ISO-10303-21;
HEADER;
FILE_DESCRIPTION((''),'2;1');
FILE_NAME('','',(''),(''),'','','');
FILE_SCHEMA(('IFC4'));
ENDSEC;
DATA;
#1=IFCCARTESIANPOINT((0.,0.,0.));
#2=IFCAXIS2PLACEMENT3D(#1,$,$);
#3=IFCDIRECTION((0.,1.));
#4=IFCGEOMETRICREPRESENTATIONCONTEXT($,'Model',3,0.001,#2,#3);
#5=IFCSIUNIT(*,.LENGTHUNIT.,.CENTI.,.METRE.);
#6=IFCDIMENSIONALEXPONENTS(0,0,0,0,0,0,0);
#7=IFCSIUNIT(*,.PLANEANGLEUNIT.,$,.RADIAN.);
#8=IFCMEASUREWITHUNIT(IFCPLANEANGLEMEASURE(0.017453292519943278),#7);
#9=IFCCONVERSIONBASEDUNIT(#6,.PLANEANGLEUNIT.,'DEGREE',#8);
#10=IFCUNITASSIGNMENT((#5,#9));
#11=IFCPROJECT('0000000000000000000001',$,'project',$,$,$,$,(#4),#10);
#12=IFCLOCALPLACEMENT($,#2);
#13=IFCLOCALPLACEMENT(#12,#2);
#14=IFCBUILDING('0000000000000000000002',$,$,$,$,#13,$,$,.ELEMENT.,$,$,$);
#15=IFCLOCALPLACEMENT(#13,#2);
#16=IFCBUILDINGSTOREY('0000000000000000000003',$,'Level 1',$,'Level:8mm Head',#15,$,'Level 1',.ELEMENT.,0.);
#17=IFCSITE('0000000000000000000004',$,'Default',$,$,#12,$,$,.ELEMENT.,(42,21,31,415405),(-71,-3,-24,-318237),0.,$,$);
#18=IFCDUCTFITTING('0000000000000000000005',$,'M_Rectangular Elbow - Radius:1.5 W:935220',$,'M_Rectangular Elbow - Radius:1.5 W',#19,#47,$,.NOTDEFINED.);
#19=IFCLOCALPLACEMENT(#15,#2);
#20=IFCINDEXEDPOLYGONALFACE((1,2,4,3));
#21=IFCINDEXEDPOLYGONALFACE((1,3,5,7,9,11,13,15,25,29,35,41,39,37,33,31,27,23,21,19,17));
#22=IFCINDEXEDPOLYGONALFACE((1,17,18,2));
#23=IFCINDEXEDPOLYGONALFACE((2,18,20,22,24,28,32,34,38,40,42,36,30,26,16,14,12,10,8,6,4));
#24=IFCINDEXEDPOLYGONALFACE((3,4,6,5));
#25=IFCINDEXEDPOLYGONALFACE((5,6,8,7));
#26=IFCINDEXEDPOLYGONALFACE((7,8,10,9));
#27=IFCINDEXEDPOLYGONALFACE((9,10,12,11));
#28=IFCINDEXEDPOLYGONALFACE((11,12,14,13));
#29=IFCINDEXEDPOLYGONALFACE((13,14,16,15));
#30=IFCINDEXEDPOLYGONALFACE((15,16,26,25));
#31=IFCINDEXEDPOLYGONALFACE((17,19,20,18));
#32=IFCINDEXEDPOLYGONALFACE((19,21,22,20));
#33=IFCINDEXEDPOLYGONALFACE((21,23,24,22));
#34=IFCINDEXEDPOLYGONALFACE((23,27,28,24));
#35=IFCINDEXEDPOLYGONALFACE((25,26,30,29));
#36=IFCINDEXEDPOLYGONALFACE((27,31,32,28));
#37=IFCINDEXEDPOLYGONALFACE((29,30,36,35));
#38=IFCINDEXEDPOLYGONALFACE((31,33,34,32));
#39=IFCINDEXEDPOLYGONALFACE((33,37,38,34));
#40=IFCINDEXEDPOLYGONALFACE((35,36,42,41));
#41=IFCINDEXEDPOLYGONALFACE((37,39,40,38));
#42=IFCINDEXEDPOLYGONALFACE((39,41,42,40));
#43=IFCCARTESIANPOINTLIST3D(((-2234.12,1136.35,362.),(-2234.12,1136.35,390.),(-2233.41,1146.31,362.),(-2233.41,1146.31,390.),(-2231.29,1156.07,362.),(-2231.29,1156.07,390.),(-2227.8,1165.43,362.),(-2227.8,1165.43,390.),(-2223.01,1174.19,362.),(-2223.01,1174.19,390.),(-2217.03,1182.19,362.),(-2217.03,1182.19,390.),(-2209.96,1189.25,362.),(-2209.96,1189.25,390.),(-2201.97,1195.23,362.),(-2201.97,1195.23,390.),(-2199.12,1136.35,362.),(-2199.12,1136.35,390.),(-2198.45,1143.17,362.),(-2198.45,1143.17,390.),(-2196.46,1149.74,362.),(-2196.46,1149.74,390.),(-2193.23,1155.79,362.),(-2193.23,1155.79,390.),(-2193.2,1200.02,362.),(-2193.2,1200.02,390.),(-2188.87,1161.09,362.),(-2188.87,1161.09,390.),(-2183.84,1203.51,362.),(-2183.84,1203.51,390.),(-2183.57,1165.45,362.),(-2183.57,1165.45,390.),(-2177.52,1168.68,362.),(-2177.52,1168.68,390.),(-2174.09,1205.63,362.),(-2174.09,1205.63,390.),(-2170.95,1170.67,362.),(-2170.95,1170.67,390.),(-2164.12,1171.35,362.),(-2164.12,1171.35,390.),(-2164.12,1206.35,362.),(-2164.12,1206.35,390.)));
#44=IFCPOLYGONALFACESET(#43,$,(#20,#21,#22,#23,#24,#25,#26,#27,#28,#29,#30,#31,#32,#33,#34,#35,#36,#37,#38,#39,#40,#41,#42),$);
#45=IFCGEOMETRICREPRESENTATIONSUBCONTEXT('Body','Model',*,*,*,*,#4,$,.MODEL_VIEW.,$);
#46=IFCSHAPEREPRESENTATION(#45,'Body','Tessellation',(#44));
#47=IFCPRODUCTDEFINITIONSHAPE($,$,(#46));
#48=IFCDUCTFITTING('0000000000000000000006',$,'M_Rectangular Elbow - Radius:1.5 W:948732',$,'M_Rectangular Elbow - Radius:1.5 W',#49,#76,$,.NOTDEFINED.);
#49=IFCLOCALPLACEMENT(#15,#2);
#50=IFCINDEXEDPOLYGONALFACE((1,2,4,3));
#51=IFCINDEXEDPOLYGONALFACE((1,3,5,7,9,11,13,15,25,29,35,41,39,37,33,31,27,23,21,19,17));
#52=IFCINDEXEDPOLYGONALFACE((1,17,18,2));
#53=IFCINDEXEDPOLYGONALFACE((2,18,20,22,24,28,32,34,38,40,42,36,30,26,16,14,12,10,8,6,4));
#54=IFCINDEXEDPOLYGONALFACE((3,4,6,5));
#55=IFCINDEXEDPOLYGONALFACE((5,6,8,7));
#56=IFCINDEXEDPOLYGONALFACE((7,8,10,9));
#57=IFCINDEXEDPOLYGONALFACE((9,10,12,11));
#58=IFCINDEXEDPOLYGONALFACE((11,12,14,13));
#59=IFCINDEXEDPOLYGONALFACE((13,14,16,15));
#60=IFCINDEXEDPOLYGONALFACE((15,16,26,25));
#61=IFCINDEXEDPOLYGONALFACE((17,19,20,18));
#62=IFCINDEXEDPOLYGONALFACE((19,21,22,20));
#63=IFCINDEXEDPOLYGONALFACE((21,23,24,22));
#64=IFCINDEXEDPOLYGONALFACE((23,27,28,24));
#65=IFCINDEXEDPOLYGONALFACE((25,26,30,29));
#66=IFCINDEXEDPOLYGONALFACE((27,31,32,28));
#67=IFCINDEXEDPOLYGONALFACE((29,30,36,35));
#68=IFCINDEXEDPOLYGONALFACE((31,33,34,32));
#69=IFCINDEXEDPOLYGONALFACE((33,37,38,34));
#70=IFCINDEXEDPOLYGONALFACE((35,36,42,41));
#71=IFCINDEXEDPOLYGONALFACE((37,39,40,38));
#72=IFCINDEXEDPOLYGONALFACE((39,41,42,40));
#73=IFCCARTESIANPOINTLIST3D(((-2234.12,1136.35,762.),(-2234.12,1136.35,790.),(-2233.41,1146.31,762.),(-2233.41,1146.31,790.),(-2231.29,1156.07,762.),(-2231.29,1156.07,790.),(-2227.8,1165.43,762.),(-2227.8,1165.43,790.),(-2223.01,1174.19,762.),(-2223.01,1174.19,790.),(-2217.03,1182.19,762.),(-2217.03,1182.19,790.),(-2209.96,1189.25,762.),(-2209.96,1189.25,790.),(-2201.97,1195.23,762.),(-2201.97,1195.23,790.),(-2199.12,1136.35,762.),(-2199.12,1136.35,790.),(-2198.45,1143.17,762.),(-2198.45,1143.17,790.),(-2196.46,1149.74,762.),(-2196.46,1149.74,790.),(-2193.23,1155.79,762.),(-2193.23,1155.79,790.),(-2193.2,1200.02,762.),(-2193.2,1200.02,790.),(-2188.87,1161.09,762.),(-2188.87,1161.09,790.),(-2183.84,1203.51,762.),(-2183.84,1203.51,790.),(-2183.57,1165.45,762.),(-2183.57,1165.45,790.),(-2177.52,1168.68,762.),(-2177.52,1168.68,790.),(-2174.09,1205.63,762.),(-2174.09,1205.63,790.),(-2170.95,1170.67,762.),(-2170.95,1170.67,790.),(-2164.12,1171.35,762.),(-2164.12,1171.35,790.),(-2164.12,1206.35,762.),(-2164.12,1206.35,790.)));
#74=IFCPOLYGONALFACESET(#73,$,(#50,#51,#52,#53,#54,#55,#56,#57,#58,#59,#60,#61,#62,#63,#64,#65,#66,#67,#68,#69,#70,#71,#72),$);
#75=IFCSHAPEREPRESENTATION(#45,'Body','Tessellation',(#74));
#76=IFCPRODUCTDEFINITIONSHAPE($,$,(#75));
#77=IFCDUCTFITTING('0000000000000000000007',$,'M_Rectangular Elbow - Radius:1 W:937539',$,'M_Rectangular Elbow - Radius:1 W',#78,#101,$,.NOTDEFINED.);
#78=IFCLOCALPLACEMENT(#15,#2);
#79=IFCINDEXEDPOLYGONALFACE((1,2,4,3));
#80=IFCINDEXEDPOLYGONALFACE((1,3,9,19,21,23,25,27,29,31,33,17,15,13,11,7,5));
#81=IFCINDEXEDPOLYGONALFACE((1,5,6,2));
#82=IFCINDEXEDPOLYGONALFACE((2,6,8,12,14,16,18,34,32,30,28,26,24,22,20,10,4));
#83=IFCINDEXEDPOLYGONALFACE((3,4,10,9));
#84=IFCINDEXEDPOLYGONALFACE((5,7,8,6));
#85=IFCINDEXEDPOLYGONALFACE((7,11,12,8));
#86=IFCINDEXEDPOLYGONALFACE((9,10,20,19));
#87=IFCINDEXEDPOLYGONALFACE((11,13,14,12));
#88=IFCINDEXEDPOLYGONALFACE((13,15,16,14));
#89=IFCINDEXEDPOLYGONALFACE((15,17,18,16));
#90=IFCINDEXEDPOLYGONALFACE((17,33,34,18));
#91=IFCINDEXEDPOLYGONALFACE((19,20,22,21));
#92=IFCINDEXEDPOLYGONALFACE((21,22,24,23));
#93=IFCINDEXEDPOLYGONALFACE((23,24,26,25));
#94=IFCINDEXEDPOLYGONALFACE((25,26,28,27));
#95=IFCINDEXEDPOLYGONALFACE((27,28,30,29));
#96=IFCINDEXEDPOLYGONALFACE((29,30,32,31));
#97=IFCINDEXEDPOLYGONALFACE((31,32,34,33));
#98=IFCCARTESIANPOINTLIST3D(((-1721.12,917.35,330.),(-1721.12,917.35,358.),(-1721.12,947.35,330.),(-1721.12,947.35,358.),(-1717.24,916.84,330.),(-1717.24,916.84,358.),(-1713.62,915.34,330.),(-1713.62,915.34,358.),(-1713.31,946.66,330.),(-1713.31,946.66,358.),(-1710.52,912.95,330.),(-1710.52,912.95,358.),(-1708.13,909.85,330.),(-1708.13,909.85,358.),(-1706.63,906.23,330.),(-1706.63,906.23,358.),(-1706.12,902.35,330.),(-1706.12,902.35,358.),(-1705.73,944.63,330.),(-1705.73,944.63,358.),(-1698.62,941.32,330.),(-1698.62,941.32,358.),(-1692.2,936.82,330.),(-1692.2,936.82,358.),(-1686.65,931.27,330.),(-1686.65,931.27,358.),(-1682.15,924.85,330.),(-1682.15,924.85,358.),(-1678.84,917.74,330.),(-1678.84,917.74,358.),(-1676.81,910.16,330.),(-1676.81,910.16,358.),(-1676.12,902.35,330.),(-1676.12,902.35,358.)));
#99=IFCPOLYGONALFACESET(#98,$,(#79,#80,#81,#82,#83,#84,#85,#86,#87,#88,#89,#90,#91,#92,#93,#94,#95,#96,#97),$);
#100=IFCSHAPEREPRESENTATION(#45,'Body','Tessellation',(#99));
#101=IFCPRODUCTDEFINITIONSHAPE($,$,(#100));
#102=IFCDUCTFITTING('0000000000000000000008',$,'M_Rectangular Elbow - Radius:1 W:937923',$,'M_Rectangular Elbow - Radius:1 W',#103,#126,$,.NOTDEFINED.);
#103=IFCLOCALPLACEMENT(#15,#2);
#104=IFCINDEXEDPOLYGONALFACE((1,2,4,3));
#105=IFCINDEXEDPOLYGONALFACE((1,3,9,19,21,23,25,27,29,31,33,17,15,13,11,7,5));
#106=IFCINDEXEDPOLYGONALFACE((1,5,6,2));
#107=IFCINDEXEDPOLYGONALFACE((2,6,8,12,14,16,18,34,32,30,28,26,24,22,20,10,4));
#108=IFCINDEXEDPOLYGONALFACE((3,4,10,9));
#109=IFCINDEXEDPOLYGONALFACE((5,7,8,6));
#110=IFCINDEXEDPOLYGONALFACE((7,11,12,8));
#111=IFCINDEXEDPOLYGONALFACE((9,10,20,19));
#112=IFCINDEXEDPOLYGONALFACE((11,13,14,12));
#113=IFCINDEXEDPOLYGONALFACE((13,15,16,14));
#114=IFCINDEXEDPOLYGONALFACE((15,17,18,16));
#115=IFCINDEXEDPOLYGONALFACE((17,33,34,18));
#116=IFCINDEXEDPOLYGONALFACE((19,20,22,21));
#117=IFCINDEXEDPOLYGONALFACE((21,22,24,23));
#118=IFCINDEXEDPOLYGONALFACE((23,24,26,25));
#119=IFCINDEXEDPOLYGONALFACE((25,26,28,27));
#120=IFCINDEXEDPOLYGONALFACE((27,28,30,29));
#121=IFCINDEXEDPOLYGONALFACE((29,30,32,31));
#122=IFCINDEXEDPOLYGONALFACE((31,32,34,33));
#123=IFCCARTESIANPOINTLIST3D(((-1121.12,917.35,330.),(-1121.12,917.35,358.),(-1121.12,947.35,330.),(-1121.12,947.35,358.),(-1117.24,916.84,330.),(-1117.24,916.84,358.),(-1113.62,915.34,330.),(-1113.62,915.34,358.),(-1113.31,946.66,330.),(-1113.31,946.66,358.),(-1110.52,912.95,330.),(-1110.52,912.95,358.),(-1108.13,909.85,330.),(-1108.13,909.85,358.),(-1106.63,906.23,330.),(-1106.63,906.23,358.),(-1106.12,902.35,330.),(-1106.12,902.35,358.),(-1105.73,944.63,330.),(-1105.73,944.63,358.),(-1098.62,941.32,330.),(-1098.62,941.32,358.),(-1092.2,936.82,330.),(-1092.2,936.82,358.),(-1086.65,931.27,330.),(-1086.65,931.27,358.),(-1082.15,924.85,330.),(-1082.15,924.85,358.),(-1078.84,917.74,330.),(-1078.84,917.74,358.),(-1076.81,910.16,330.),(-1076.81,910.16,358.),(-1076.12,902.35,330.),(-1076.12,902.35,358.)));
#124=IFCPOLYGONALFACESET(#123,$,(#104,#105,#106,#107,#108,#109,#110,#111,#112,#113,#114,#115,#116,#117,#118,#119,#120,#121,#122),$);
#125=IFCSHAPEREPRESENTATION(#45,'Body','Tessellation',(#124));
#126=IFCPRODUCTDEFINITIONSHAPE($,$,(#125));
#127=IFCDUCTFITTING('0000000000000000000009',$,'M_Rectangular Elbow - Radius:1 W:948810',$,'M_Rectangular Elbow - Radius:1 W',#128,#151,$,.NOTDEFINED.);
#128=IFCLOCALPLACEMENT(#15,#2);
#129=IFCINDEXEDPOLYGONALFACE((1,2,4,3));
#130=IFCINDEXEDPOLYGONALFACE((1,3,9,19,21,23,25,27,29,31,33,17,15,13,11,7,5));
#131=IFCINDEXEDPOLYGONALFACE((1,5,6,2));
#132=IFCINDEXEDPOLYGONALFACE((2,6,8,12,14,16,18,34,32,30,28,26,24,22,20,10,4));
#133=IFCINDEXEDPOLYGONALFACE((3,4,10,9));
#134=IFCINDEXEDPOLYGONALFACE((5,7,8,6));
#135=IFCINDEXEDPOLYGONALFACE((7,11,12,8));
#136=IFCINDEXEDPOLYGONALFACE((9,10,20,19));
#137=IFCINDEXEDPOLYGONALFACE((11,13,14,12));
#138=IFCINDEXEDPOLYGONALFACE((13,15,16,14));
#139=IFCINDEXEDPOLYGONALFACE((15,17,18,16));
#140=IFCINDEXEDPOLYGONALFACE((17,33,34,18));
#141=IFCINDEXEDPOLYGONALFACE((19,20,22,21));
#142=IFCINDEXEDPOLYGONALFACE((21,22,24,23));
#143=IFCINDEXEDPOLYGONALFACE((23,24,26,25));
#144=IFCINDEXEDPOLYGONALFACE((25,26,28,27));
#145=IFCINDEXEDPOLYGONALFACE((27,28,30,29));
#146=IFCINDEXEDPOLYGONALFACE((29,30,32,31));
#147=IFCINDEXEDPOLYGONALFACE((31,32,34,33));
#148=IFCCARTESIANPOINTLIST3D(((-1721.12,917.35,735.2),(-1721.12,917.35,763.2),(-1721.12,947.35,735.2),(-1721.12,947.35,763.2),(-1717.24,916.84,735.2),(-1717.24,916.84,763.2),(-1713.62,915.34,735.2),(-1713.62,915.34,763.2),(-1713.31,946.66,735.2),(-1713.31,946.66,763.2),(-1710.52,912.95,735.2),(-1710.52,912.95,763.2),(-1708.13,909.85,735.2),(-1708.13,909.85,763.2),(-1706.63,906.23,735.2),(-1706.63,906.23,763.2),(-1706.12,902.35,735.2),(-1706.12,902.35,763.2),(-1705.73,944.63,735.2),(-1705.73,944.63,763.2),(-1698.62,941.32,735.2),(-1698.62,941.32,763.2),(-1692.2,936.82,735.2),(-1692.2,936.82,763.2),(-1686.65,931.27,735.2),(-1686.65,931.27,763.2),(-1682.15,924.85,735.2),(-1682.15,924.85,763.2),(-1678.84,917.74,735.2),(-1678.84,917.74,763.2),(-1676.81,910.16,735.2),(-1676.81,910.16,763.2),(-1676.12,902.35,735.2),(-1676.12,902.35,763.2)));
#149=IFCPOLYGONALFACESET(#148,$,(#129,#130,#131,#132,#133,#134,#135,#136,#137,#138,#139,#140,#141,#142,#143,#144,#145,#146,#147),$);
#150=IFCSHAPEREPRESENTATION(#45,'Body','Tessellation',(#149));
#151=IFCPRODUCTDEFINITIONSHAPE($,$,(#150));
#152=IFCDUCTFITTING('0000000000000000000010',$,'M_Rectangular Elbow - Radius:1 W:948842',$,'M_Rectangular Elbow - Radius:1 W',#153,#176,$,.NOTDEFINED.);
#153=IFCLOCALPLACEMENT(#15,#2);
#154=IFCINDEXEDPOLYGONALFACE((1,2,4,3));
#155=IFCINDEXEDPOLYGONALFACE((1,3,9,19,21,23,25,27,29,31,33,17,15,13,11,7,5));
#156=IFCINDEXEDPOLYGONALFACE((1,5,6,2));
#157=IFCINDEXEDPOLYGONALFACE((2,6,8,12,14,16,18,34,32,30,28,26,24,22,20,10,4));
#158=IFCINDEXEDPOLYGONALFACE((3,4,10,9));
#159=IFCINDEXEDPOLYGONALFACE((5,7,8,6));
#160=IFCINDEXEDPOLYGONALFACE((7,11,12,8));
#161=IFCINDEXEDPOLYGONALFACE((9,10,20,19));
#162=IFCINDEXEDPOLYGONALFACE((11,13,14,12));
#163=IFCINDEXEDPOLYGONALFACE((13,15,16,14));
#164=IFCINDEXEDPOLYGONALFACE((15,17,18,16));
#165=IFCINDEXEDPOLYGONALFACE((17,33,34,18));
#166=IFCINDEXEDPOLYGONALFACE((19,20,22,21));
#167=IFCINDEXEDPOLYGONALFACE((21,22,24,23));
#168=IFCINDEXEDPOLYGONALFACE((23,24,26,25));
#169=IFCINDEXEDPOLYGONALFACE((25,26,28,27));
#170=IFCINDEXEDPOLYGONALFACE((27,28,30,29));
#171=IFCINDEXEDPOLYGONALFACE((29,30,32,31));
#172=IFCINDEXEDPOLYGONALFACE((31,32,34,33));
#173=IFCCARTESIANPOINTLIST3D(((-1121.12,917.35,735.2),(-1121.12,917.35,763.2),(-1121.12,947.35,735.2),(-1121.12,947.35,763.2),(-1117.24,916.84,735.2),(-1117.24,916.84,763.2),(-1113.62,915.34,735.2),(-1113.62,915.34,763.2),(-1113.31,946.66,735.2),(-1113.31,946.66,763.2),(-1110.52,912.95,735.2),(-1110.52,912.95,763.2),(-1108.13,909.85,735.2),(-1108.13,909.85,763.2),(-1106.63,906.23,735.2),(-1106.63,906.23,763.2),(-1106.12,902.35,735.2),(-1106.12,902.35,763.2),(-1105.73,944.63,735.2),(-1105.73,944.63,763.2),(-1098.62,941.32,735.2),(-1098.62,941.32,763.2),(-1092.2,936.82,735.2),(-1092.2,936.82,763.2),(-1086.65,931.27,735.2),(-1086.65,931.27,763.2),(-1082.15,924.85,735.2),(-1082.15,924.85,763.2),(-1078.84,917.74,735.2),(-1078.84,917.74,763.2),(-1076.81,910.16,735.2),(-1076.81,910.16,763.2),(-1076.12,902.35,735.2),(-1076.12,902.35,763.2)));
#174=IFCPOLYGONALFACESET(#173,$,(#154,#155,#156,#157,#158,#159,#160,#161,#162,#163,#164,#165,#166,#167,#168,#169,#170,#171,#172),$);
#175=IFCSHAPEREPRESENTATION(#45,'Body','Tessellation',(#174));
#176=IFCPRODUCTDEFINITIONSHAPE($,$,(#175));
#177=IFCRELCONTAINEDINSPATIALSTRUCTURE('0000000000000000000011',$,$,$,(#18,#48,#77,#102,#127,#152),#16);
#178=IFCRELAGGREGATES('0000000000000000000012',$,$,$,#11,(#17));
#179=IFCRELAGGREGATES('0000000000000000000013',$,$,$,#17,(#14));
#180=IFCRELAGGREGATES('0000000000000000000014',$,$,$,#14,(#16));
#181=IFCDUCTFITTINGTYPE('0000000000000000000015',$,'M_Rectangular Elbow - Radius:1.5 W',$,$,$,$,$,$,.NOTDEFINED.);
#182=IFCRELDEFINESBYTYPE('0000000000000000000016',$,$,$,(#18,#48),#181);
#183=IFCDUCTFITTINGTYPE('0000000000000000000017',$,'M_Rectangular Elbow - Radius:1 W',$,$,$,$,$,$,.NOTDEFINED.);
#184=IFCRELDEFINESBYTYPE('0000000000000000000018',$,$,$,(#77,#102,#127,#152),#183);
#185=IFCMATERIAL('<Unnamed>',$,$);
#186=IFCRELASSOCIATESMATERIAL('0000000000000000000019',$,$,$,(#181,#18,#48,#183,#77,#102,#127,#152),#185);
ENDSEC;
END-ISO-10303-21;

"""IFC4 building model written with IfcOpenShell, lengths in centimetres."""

from ifc_helpers import new_model, entity, si_unit, converted_unit, direction, frame, origin, place, context, subcontext, project, spatial, line, arc, indexed_curve, outline, extrude, source, transform, mapped, material, type_object, type_shapes, element, save


model = new_model("IFC4")

# Units and contexts
model_context = context("Model", 3, precision=0.001, world=origin(), true_north=direction((0.0, 1.0)))
body_context = subcontext(model_context, "Body", "Model", "MODEL_VIEW")
ifc_project = project(units=[si_unit("LENGTHUNIT", "METRE", prefix="CENTI"), converted_unit("PLANEANGLEUNIT", "DEGREE", entity("IfcPlaneAngleMeasure", 0.017453292519943278), si_unit("PLANEANGLEUNIT", "RADIAN"), dimensions=[0, 0, 0, 0, 0, 0, 0])], contexts=[model_context])

# Site, building, storey
site_placement = place(None, origin())
site = spatial("IfcSite", under=ifc_project, at=site_placement, Name="Default", CompositionType="ELEMENT", RefLatitude=(42, 21, 31, 415405), RefLongitude=(-71, -3, -24, -318237), RefElevation=0.0)
building_placement = place(site_placement, origin())
building = spatial("IfcBuilding", under=site, at=building_placement, CompositionType="ELEMENT")
storey_placement = place(building_placement, origin())
storey = spatial("IfcBuildingStorey", under=building, at=storey_placement, Name="Level 1", ObjectType="Level:8mm Head", LongName="Level 1", CompositionType="ELEMENT", Elevation=0.0)

# Duct fittings
ifc_material = material(Name="<Unnamed>")
duct_fitting_type_1 = type_object("IfcDuctFittingType", Name="M_Rectangular Elbow - Radius:1.5 W", PredefinedType="NOTDEFINED", material=ifc_material)
shared_shape_1 = source(origin(), body_context, "Body", "SweptSolid", [
    extrude(outline(indexed_curve([(-43.75, -26.25), (-8.75, -26.25), (1.5, -1.5), (26.25, 8.75), (26.25, 43.75), (-23.25, 23.25)], segments=[line(1, 2), arc(2, 3, 4), line(4, 5), arc(5, 6, 1)], self_intersect=False)), frame((-26.25, 26.25, -14.0), z_axis=(0.0, 0.0, 1.0), x_axis=(-1.0, 0.0, 0.0)), (0.0, 0.0, 1.0), 28.0),
])
type_shapes(duct_fitting_type_1, [shared_shape_1])
for number, where, z_axis, x_axis, name in (
    (1, (-2216.62, 1188.85, 376.0), (0.0, 0.0, 1.0), (-1.0, 0.0, 0.0), "M_Rectangular Elbow - Radius:1.5 W:935220"),
    (2, (-2216.62, 1188.85, 776.0), (0.0, 0.0, 1.0), (-1.0, 0.0, 0.0), "M_Rectangular Elbow - Radius:1.5 W:948732"),
):
    element("IfcDuctFitting", number, at=place(storey_placement, frame(where, z_axis=z_axis, x_axis=x_axis)), inside=storey, type_object=duct_fitting_type_1, material=ifc_material, Name=name, ObjectType="M_Rectangular Elbow - Radius:1.5 W", PredefinedType="NOTDEFINED", context=body_context, shape_type="MappedRepresentation", body=[
        mapped(shared_shape_1, transform((0.0, 0.0, 0.0), scale=1.0)),
    ])
duct_fitting_type_2 = type_object("IfcDuctFittingType", Name="M_Rectangular Elbow - Radius:1 W", PredefinedType="NOTDEFINED", material=ifc_material)
shared_shape_2 = source(origin(), body_context, "Body", "SweptSolid", [
    extrude(outline(indexed_curve([(-30.0, -15.0), (0.0, -15.0), (4.39, -4.39), (15.0, 0.0), (15.0, 30.0), (-16.82, 16.82)], segments=[line(1, 2), arc(2, 3, 4), line(4, 5), arc(5, 6, 1)], self_intersect=False)), frame((-15.0, 15.0, -14.0), z_axis=(0.0, 0.0, 1.0), x_axis=(-1.0, 0.0, 0.0)), (0.0, 0.0, 1.0), 28.0),
])
type_shapes(duct_fitting_type_2, [shared_shape_2])
for number, where, z_axis, x_axis, name in (
    (3, (-1691.12, 932.35, 344.0), (0.0, 0.0, 1.0), (0.0, 1.0, 0.0), "M_Rectangular Elbow - Radius:1 W:937539"),
    (4, (-1091.12, 932.35, 344.0), (0.0, 0.0, 1.0), (0.0, 1.0, 0.0), "M_Rectangular Elbow - Radius:1 W:937923"),
    (5, (-1691.12, 932.35, 749.2), (0.0, 0.0, 1.0), (0.0, 1.0, 0.0), "M_Rectangular Elbow - Radius:1 W:948810"),
    (6, (-1091.12, 932.35, 749.2), (0.0, 0.0, 1.0), (0.0, 1.0, 0.0), "M_Rectangular Elbow - Radius:1 W:948842"),
):
    element("IfcDuctFitting", number, at=place(storey_placement, frame(where, z_axis=z_axis, x_axis=x_axis)), inside=storey, type_object=duct_fitting_type_2, material=ifc_material, Name=name, ObjectType="M_Rectangular Elbow - Radius:1 W", PredefinedType="NOTDEFINED", context=body_context, shape_type="MappedRepresentation", body=[
        mapped(shared_shape_2, transform((0.0, 0.0, 0.0), scale=1.0)),
    ])

save(model, "model.ifc")
